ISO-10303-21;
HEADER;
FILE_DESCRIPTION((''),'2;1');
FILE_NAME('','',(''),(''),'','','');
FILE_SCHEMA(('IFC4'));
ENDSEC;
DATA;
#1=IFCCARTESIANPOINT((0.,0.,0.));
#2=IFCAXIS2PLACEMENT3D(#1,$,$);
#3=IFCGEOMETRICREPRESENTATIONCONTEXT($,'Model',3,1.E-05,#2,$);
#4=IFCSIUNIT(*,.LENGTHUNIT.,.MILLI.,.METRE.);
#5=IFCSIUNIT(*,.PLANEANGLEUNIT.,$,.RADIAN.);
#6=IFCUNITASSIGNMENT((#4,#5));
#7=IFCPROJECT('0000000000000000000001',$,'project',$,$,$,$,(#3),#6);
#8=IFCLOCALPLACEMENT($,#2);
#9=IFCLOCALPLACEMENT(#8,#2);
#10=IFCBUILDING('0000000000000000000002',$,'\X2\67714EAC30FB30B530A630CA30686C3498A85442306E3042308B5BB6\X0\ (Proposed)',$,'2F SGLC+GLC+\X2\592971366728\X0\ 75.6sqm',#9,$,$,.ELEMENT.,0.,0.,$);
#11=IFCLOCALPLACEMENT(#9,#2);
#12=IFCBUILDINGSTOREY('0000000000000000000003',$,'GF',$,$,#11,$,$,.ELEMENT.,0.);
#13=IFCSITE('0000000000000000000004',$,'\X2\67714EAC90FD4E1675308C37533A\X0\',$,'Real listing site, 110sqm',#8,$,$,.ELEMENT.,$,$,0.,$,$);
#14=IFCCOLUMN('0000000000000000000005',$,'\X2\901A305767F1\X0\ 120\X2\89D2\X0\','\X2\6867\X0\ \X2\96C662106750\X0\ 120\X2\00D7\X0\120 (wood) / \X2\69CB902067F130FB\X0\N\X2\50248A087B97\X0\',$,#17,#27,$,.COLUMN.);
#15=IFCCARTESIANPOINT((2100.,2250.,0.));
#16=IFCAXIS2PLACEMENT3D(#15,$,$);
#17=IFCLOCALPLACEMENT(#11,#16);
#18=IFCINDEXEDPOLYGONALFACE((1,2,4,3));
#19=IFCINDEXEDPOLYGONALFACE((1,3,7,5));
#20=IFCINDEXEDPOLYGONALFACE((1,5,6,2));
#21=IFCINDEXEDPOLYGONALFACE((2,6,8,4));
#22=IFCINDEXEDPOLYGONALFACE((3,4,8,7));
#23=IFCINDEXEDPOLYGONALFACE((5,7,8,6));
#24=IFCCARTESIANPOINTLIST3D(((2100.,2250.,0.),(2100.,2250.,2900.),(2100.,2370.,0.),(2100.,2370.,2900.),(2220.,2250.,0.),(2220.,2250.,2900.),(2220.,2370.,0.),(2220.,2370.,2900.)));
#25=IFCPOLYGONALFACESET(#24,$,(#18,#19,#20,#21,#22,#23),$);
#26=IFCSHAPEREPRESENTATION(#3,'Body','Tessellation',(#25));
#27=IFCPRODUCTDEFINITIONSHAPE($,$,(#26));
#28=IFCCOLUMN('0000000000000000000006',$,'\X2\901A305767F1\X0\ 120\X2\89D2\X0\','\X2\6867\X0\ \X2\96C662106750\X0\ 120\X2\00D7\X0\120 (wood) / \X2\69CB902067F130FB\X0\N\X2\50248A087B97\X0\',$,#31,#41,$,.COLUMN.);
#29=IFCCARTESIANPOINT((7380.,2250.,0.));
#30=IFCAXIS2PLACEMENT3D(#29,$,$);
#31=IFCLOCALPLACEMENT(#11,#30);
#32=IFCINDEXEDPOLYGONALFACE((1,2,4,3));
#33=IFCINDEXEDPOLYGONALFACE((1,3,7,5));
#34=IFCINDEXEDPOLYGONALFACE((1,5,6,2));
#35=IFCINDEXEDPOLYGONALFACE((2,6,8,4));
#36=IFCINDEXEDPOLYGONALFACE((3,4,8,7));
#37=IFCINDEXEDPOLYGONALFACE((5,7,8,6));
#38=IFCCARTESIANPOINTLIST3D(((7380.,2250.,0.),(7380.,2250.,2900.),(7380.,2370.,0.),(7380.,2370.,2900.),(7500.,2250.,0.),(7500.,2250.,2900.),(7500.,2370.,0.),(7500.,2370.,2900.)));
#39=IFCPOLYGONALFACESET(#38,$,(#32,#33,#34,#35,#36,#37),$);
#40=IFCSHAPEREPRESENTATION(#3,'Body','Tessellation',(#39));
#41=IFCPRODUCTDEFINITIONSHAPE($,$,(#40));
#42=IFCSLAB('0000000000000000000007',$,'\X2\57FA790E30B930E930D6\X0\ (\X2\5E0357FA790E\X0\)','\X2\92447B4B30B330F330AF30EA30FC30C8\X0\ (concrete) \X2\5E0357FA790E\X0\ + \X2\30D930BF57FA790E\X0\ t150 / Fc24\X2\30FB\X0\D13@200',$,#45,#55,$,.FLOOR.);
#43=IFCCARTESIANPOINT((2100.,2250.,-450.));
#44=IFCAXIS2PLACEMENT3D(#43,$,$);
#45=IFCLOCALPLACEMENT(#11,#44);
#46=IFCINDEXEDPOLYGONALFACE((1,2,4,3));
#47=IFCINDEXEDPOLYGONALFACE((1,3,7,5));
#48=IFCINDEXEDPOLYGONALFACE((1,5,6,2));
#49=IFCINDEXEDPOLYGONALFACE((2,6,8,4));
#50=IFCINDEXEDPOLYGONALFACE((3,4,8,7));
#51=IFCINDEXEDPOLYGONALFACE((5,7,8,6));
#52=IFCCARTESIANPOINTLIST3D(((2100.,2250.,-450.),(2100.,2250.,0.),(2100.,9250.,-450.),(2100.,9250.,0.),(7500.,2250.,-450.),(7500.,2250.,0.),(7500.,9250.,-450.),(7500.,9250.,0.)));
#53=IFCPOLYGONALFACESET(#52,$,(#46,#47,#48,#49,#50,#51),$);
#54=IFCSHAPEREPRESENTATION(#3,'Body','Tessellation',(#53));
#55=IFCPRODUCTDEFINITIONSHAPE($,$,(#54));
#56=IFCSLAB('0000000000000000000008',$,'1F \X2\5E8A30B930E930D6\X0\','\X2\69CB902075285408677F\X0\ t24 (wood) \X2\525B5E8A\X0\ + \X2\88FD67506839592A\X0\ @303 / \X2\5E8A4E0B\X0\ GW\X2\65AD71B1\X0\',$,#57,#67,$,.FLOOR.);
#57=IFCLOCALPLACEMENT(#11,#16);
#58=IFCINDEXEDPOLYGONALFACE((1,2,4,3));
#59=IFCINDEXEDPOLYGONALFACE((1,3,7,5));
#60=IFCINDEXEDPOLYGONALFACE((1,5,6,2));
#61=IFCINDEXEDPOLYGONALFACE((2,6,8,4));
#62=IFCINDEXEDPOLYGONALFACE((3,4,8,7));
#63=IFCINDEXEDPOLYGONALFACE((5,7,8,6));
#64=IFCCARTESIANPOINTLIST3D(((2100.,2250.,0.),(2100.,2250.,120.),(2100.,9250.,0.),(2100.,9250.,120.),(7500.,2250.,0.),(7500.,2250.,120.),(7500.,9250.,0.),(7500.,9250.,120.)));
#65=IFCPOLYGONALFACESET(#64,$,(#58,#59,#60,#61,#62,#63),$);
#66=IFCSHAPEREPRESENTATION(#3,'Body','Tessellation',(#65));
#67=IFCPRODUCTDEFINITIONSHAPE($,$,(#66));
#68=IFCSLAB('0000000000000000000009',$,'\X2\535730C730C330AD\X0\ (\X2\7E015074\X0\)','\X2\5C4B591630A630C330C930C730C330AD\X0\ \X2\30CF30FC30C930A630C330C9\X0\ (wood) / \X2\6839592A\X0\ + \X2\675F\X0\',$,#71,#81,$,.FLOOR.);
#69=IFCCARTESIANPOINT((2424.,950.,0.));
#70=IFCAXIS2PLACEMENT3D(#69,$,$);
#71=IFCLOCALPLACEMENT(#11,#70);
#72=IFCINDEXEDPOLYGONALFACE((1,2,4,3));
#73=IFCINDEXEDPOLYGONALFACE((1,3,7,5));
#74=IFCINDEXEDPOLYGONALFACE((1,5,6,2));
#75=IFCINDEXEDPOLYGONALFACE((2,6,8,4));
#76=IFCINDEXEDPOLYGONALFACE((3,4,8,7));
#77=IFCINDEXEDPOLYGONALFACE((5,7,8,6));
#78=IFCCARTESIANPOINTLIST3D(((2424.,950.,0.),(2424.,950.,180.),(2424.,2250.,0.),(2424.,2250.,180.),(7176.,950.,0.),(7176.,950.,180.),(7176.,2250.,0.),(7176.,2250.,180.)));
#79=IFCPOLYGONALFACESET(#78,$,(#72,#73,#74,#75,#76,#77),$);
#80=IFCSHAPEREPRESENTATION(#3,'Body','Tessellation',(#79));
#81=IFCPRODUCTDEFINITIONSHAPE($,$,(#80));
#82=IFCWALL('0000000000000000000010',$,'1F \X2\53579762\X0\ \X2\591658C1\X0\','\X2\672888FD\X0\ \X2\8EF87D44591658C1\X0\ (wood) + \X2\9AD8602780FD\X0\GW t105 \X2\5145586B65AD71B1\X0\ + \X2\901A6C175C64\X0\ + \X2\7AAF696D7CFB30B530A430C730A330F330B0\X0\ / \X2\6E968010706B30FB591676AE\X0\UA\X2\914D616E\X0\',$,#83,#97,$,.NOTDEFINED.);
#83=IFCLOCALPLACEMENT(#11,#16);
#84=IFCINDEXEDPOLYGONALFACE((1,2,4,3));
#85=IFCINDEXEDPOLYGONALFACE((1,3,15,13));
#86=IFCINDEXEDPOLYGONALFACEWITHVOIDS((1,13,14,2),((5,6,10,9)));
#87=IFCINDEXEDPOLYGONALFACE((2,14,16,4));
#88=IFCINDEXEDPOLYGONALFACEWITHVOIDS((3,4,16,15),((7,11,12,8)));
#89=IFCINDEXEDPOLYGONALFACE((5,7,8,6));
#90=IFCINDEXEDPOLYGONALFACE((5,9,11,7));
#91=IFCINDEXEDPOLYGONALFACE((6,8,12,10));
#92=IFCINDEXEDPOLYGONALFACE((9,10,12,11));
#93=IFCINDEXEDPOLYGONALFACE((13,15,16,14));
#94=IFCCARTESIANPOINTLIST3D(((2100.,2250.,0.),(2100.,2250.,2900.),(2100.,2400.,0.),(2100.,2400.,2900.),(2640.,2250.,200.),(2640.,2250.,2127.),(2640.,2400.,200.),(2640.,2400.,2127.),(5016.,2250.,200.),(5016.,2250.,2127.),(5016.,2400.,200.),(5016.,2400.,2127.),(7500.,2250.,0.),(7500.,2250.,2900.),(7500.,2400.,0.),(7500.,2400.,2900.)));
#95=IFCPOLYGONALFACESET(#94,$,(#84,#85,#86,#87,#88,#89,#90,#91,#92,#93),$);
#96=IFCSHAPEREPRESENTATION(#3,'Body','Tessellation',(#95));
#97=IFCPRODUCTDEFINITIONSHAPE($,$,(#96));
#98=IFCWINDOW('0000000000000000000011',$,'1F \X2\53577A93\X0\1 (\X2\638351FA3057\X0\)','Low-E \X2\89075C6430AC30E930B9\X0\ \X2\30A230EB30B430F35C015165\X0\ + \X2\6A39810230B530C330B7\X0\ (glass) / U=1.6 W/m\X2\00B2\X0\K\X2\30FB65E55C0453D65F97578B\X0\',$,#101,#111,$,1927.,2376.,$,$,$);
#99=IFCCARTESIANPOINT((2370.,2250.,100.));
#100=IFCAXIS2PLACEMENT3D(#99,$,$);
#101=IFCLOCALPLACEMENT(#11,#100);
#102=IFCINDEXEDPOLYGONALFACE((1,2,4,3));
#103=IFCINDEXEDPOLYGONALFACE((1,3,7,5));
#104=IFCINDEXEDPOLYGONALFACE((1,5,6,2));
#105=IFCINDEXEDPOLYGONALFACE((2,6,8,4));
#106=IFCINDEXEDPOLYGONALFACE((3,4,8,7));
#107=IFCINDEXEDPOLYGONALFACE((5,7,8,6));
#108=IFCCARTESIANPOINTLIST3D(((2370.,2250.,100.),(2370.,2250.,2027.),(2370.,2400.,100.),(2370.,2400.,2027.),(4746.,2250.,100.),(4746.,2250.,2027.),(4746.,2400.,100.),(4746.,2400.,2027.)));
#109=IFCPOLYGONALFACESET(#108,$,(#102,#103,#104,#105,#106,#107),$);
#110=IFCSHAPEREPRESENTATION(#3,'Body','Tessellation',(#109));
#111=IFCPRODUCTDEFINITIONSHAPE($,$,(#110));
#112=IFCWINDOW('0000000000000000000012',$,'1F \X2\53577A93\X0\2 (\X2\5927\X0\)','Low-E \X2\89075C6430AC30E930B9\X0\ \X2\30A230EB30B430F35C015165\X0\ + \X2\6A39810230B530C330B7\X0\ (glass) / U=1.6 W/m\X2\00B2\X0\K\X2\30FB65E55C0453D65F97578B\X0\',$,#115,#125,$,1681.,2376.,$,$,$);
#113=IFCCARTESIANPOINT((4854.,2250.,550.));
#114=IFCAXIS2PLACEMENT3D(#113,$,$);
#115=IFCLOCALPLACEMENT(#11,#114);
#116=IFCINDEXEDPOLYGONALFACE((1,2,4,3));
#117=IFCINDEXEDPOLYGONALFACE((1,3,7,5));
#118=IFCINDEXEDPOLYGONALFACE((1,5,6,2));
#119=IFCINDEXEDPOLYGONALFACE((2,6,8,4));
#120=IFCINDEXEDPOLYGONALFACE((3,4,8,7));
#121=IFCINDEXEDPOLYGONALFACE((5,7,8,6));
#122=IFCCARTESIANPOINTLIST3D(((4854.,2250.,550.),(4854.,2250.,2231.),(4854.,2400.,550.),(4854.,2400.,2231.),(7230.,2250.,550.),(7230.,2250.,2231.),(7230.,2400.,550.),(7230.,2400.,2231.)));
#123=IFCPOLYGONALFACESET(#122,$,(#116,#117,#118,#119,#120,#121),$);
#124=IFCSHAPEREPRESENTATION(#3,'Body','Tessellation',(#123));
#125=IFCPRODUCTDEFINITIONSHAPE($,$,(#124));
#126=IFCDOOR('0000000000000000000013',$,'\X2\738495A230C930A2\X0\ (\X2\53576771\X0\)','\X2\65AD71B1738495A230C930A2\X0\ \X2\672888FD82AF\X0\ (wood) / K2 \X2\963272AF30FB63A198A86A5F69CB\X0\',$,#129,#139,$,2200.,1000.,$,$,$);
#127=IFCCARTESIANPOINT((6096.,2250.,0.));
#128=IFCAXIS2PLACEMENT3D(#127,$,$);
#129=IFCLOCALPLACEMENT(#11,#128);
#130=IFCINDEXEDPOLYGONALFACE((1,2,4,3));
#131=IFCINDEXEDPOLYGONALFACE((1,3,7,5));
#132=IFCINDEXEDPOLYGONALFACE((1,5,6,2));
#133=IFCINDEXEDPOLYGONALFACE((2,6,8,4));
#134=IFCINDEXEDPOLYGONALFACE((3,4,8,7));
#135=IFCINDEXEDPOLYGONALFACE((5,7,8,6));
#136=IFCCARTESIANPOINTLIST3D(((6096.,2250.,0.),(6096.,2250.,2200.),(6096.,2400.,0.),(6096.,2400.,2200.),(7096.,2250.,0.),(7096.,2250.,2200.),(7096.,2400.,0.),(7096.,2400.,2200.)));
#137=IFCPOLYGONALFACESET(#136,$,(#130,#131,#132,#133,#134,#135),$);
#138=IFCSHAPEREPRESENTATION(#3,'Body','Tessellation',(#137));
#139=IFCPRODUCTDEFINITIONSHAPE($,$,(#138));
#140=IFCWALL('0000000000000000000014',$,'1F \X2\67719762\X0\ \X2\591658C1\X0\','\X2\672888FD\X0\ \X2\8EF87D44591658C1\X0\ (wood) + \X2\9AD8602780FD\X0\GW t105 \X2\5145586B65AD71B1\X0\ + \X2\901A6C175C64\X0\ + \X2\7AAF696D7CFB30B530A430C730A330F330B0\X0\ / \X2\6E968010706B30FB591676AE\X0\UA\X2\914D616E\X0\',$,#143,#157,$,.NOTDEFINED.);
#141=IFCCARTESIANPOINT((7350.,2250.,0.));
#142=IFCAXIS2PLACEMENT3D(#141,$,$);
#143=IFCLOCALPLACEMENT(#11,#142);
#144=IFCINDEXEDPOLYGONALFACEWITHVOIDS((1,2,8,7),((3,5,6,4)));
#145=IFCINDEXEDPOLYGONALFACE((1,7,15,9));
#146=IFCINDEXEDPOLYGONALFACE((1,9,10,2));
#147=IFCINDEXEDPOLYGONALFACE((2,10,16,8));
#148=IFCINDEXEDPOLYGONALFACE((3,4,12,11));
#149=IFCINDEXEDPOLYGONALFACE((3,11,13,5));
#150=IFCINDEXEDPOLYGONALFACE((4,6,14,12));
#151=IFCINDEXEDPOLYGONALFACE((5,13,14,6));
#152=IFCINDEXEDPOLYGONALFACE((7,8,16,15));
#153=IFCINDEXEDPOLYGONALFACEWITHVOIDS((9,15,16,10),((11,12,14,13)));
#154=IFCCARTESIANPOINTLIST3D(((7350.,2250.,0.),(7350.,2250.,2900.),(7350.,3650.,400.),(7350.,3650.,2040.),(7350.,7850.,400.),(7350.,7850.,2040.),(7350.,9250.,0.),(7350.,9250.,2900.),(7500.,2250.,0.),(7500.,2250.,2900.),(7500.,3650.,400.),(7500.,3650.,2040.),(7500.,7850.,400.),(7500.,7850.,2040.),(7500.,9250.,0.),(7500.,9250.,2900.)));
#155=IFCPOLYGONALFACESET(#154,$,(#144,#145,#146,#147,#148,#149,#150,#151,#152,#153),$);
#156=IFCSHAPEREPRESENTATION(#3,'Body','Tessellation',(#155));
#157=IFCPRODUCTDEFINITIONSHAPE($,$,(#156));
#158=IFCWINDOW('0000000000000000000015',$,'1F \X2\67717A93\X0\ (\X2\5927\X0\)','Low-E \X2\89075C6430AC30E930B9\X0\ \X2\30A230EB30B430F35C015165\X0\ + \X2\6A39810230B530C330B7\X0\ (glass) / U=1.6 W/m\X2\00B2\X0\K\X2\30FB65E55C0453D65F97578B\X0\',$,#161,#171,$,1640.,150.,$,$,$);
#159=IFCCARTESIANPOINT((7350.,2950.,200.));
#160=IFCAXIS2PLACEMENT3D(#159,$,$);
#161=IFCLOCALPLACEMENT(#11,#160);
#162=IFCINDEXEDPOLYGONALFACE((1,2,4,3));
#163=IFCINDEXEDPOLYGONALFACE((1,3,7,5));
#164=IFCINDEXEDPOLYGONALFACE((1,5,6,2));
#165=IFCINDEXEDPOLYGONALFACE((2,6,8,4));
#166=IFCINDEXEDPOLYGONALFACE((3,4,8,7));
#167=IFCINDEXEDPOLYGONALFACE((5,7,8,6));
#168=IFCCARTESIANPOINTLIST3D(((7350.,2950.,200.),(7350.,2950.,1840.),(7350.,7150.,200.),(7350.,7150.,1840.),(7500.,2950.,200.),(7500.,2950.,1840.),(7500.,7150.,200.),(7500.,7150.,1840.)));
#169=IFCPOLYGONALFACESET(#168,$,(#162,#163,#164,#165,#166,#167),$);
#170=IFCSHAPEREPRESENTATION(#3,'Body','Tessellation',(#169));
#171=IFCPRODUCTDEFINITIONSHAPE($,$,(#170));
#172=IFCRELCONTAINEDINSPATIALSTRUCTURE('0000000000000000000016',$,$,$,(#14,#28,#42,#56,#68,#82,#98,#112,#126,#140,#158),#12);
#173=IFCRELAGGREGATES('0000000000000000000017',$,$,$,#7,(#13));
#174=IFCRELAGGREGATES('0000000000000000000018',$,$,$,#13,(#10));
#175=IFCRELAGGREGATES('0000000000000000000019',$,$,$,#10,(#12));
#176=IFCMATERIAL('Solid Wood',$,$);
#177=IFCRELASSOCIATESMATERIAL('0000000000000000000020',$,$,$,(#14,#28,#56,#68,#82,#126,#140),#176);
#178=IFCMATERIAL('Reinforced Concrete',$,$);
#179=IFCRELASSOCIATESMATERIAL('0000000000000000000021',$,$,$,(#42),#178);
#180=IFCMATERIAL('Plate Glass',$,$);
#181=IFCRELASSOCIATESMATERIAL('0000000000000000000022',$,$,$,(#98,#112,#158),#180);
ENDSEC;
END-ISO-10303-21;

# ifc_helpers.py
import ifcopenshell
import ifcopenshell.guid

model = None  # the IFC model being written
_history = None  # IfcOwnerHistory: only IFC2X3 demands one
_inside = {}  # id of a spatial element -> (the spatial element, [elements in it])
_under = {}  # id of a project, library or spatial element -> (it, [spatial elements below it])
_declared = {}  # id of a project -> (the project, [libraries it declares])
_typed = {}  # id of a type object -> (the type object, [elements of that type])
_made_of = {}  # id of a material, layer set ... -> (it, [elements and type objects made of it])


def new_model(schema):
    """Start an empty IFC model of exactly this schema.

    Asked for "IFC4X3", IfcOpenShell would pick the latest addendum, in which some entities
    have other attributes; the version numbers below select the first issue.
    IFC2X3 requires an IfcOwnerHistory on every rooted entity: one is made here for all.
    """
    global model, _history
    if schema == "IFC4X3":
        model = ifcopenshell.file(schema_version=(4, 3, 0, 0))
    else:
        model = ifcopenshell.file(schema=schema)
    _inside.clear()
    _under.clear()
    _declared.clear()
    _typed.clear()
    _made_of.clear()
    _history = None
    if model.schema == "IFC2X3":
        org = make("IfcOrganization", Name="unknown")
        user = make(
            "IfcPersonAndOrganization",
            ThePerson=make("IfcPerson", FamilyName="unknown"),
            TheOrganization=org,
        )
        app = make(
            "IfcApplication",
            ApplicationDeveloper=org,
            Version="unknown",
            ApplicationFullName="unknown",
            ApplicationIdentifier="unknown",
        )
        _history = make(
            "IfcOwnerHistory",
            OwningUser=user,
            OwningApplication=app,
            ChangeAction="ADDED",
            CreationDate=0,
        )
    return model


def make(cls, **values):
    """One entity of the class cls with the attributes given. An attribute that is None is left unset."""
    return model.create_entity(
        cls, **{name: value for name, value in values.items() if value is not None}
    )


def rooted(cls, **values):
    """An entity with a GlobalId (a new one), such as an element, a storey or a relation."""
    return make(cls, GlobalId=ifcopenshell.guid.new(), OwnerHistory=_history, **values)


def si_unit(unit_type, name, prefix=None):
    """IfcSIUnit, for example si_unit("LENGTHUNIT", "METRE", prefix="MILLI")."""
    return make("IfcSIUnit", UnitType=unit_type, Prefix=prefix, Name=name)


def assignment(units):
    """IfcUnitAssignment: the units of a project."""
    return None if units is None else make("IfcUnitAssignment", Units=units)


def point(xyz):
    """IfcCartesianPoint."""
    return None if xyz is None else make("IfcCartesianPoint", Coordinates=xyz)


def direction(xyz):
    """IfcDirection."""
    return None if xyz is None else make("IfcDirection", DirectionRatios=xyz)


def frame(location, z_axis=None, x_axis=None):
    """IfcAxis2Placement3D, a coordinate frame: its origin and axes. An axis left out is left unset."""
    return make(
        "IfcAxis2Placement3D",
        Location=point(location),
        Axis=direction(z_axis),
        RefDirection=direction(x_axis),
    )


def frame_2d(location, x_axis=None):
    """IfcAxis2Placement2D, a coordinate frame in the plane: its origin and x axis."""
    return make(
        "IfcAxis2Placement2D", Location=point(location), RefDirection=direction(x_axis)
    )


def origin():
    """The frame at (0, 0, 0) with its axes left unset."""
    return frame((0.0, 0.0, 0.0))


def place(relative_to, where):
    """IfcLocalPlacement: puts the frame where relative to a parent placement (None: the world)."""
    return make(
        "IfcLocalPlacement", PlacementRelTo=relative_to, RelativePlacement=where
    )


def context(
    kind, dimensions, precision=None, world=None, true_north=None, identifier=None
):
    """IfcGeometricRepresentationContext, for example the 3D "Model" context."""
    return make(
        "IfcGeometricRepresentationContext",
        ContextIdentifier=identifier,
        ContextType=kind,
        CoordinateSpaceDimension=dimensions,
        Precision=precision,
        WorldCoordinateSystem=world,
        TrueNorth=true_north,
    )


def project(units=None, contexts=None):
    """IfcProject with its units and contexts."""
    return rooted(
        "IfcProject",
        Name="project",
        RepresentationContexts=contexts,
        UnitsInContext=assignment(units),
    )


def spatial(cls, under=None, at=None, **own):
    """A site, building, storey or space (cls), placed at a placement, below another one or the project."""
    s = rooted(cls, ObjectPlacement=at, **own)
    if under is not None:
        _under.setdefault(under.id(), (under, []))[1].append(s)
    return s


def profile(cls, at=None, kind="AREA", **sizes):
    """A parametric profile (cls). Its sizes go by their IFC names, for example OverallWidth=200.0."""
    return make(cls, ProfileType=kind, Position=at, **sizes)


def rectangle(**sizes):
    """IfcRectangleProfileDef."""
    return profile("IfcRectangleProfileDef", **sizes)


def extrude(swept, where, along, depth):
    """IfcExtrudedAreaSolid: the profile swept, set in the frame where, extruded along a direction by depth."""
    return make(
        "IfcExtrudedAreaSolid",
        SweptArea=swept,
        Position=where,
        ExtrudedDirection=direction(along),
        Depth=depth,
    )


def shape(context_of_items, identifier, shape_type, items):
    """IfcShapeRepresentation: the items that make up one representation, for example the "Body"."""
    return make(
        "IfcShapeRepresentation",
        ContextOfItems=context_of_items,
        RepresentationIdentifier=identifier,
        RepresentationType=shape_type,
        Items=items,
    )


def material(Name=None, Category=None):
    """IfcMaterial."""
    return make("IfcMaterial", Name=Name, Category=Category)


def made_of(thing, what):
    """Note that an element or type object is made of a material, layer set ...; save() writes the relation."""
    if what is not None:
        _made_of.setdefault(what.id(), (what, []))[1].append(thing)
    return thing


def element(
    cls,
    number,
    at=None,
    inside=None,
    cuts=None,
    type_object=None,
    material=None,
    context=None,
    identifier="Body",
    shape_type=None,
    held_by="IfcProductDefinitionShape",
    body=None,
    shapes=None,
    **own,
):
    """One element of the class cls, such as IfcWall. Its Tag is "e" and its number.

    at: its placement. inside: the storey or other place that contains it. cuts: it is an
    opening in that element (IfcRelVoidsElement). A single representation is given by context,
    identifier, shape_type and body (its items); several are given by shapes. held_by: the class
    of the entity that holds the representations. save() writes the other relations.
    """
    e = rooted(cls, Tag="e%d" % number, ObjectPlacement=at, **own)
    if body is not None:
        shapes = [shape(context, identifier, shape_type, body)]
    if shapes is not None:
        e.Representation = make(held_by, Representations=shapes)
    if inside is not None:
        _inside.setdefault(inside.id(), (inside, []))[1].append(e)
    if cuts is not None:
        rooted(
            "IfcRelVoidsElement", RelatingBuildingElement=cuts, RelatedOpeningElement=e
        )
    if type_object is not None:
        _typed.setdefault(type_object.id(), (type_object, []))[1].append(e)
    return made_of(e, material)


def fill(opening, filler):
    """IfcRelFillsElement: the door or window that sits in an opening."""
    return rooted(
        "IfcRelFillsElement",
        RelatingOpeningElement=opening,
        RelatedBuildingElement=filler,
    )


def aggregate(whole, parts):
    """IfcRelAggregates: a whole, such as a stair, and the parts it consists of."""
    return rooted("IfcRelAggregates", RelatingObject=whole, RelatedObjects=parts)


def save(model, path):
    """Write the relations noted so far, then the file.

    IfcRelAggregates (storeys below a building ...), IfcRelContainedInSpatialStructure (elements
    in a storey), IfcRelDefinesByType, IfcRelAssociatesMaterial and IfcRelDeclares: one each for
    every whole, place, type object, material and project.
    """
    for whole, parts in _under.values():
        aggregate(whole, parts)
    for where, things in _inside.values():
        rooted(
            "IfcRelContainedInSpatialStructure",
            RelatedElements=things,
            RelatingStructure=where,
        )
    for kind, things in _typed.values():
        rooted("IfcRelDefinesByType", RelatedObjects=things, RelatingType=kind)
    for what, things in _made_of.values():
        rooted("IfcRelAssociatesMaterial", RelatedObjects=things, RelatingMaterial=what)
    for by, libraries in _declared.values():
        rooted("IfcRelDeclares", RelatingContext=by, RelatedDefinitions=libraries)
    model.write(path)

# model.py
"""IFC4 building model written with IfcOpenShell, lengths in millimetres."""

from ifc_helpers import new_model, si_unit, frame, frame_2d, origin, place, context, project, spatial, rectangle, extrude, material, element, fill, save


model = new_model("IFC4")

# Units and contexts
model_context = context("Model", 3, precision=1e-05, world=origin())
ifc_project = project(units=[si_unit("LENGTHUNIT", "METRE", prefix="MILLI"), si_unit("PLANEANGLEUNIT", "RADIAN")], contexts=[model_context])

# Site, building, storey
site_placement = place(None, origin())
site = spatial("IfcSite", under=ifc_project, at=site_placement, Name="東京都世田谷区", ObjectType="Real listing site, 110sqm", CompositionType="ELEMENT", RefElevation=0.0)
building_placement = place(site_placement, origin())
building = spatial("IfcBuilding", under=site, at=building_placement, Name="東京・サウナと水風呂のある家 (Proposed)", ObjectType="2F SGLC+GLC+天然木 75.6sqm", CompositionType="ELEMENT", ElevationOfRefHeight=0.0, ElevationOfTerrain=0.0)
storey_placement = place(building_placement, origin())
storey = spatial("IfcBuildingStorey", under=building, at=storey_placement, Name="GF", CompositionType="ELEMENT", Elevation=0.0)

# Columns
ifc_material_1 = material(Name="Solid Wood")
column_1_placement = place(storey_placement, frame((2100.0, 2250.0, 0.0)))
element("IfcColumn", 1, at=column_1_placement, inside=storey, material=ifc_material_1, Name="通し柱 120角", Description="桧 集成材 120×120 (wood) / 構造柱・N値計算", PredefinedType="COLUMN", context=model_context, shape_type="SweptSolid", body=[
    extrude(rectangle(XDim=120.0, YDim=120.0, at=frame_2d((60.0, 60.0))), frame((2100.0, 2250.0, 0.0)), (0.0, 0.0, 1.0), 2900.0),
])
column_2_placement = place(storey_placement, frame((7380.0, 2250.0, 0.0)))
element("IfcColumn", 2, at=column_2_placement, inside=storey, material=ifc_material_1, Name="通し柱 120角", Description="桧 集成材 120×120 (wood) / 構造柱・N値計算", PredefinedType="COLUMN", context=model_context, shape_type="SweptSolid", body=[
    extrude(rectangle(XDim=120.0, YDim=120.0, at=frame_2d((60.0, 60.0))), frame((7380.0, 2250.0, 0.0)), (0.0, 0.0, 1.0), 2900.0),
])

# Slabs
ifc_material_2 = material(Name="Reinforced Concrete")
slab_1_placement = place(storey_placement, frame((2100.0, 2250.0, -450.0)))
element("IfcSlab", 3, at=slab_1_placement, inside=storey, material=ifc_material_2, Name="基礎スラブ (布基礎)", Description="鉄筋コンクリート (concrete) 布基礎 + ベタ基礎 t150 / Fc24・D13@200", PredefinedType="FLOOR", context=model_context, shape_type="SweptSolid", body=[
    extrude(rectangle(XDim=5400.0, YDim=7000.0, at=frame_2d((2700.0, 3500.0))), frame((2100.0, 2250.0, -450.0)), (0.0, 0.0, 1.0), 450.0),
])
slab_2_placement = place(storey_placement, frame((2100.0, 2250.0, 0.0)))
element("IfcSlab", 4, at=slab_2_placement, inside=storey, material=ifc_material_1, Name="1F 床スラブ", Description="構造用合板 t24 (wood) 剛床 + 製材根太 @303 / 床下 GW断熱", PredefinedType="FLOOR", context=model_context, shape_type="SweptSolid", body=[
    extrude(rectangle(XDim=5400.0, YDim=7000.0, at=frame_2d((2700.0, 3500.0))), frame((2100.0, 2250.0, 0.0)), (0.0, 0.0, 1.0), 120.0),
])
slab_3_placement = place(storey_placement, frame((2424.0, 950.0, 0.0)))
element("IfcSlab", 5, at=slab_3_placement, inside=storey, material=ifc_material_1, Name="南デッキ (縁側)", Description="屋外ウッドデッキ ハードウッド (wood) / 根太 + 束", PredefinedType="FLOOR", context=model_context, shape_type="SweptSolid", body=[
    extrude(rectangle(XDim=4752.0, YDim=1300.0, at=frame_2d((2376.0, 650.0))), frame((2424.0, 950.0, 0.0)), (0.0, 0.0, 1.0), 180.0),
])

# Wall, openings, windows, door
wall_1_placement = place(storey_placement, frame((2100.0, 2250.0, 0.0)))
wall_1 = element("IfcWall", 6, at=wall_1_placement, inside=storey, material=ifc_material_1, Name="1F 南面 外壁", Description="木製 軸組外壁 (wood) + 高性能GW t105 充填断熱 + 通気層 + 窯業系サイディング / 準耐火・外皮UA配慮", PredefinedType="NOTDEFINED", context=model_context, shape_type="SweptSolid", body=[
    extrude(rectangle(XDim=5400.0, YDim=150.0, at=frame_2d((2700.0, 75.0))), frame((2100.0, 2250.0, 0.0)), (0.0, 0.0, 1.0), 2900.0),
])
opening_1_placement = place(storey_placement, frame((2370.0, 2250.0, 100.0)))
opening_1 = element("IfcOpeningElement", 7, at=opening_1_placement, cuts=wall_1, PredefinedType="NOTDEFINED", context=model_context, shape_type="SweptSolid", body=[
    extrude(rectangle(XDim=2376.0, YDim=150.0, at=frame_2d((1188.0, 75.0))), frame((2370.0, 2250.0, 100.0)), (0.0, 0.0, 1.0), 1927.0),
])
opening_2_placement = place(storey_placement, frame((4854.0, 2250.0, 550.0)))
opening_2 = element("IfcOpeningElement", 8, at=opening_2_placement, cuts=wall_1, PredefinedType="NOTDEFINED", context=model_context, shape_type="SweptSolid", body=[
    extrude(rectangle(XDim=2376.0, YDim=150.0, at=frame_2d((1188.0, 75.0))), frame((4854.0, 2250.0, 550.0)), (0.0, 0.0, 1.0), 1681.0),
])
opening_3_placement = place(storey_placement, frame((6096.0, 2250.0, 0.0)))
opening_3 = element("IfcOpeningElement", 9, at=opening_3_placement, cuts=wall_1, PredefinedType="NOTDEFINED", context=model_context, shape_type="SweptSolid", body=[
    extrude(rectangle(XDim=1000.0, YDim=150.0, at=frame_2d((500.0, 75.0))), frame((6096.0, 2250.0, 0.0)), (0.0, 0.0, 1.0), 2200.0),
])
ifc_material_3 = material(Name="Plate Glass")
window_1_placement = place(storey_placement, frame((2370.0, 2250.0, 100.0)))
window_1 = element("IfcWindow", 10, at=window_1_placement, inside=storey, material=ifc_material_3, Name="1F 南窓1 (掃出し)", Description="Low-E 複層ガラス アルゴン封入 + 樹脂サッシ (glass) / U=1.6 W/m²K・日射取得型", OverallHeight=1927.0, OverallWidth=2376.0, context=model_context, shape_type="SweptSolid", body=[
    extrude(rectangle(XDim=2376.0, YDim=150.0, at=frame_2d((1188.0, 75.0))), frame((2370.0, 2250.0, 100.0)), (0.0, 0.0, 1.0), 1927.0),
])
fill(opening_1, window_1)
window_2_placement = place(storey_placement, frame((4854.0, 2250.0, 550.0)))
window_2 = element("IfcWindow", 11, at=window_2_placement, inside=storey, material=ifc_material_3, Name="1F 南窓2 (大)", Description="Low-E 複層ガラス アルゴン封入 + 樹脂サッシ (glass) / U=1.6 W/m²K・日射取得型", OverallHeight=1681.0, OverallWidth=2376.0, context=model_context, shape_type="SweptSolid", body=[
    extrude(rectangle(XDim=2376.0, YDim=150.0, at=frame_2d((1188.0, 75.0))), frame((4854.0, 2250.0, 550.0)), (0.0, 0.0, 1.0), 1681.0),
])
fill(opening_2, window_2)
door_placement = place(storey_placement, frame((6096.0, 2250.0, 0.0)))
door = element("IfcDoor", 12, at=door_placement, inside=storey, material=ifc_material_1, Name="玄関ドア (南東)", Description="断熱玄関ドア 木製芯 (wood) / K2 防犯・採風機構", OverallHeight=2200.0, OverallWidth=1000.0, context=model_context, shape_type="SweptSolid", body=[
    extrude(rectangle(XDim=1000.0, YDim=150.0, at=frame_2d((500.0, 75.0))), frame((6096.0, 2250.0, 0.0)), (0.0, 0.0, 1.0), 2200.0),
])
fill(opening_3, door)

# Wall, opening, window
wall_2_placement = place(storey_placement, frame((7350.0, 2250.0, 0.0)))
wall_2 = element("IfcWall", 13, at=wall_2_placement, inside=storey, material=ifc_material_1, Name="1F 東面 外壁", Description="木製 軸組外壁 (wood) + 高性能GW t105 充填断熱 + 通気層 + 窯業系サイディング / 準耐火・外皮UA配慮", PredefinedType="NOTDEFINED", context=model_context, shape_type="SweptSolid", body=[
    extrude(rectangle(XDim=150.0, YDim=7000.0, at=frame_2d((75.0, 3500.0))), frame((7350.0, 2250.0, 0.0)), (0.0, 0.0, 1.0), 2900.0),
])
opening_4_placement = place(storey_placement, frame((7350.0, 2950.0, 200.0)))
opening_4 = element("IfcOpeningElement", 14, at=opening_4_placement, cuts=wall_2, PredefinedType="NOTDEFINED", context=model_context, shape_type="SweptSolid", body=[
    extrude(rectangle(XDim=150.0, YDim=4200.0, at=frame_2d((75.0, 2100.0))), frame((7350.0, 2950.0, 200.0)), (0.0, 0.0, 1.0), 1640.0),
])
window_3_placement = place(storey_placement, frame((7350.0, 2950.0, 200.0)))
window_3 = element("IfcWindow", 15, at=window_3_placement, inside=storey, material=ifc_material_3, Name="1F 東窓 (大)", Description="Low-E 複層ガラス アルゴン封入 + 樹脂サッシ (glass) / U=1.6 W/m²K・日射取得型", OverallHeight=1640.0, OverallWidth=150.0, context=model_context, shape_type="SweptSolid", body=[
    extrude(rectangle(XDim=150.0, YDim=4200.0, at=frame_2d((75.0, 2100.0))), frame((7350.0, 2950.0, 200.0)), (0.0, 0.0, 1.0), 1640.0),
])
fill(opening_4, window_3)

save(model, "model.ifc")
